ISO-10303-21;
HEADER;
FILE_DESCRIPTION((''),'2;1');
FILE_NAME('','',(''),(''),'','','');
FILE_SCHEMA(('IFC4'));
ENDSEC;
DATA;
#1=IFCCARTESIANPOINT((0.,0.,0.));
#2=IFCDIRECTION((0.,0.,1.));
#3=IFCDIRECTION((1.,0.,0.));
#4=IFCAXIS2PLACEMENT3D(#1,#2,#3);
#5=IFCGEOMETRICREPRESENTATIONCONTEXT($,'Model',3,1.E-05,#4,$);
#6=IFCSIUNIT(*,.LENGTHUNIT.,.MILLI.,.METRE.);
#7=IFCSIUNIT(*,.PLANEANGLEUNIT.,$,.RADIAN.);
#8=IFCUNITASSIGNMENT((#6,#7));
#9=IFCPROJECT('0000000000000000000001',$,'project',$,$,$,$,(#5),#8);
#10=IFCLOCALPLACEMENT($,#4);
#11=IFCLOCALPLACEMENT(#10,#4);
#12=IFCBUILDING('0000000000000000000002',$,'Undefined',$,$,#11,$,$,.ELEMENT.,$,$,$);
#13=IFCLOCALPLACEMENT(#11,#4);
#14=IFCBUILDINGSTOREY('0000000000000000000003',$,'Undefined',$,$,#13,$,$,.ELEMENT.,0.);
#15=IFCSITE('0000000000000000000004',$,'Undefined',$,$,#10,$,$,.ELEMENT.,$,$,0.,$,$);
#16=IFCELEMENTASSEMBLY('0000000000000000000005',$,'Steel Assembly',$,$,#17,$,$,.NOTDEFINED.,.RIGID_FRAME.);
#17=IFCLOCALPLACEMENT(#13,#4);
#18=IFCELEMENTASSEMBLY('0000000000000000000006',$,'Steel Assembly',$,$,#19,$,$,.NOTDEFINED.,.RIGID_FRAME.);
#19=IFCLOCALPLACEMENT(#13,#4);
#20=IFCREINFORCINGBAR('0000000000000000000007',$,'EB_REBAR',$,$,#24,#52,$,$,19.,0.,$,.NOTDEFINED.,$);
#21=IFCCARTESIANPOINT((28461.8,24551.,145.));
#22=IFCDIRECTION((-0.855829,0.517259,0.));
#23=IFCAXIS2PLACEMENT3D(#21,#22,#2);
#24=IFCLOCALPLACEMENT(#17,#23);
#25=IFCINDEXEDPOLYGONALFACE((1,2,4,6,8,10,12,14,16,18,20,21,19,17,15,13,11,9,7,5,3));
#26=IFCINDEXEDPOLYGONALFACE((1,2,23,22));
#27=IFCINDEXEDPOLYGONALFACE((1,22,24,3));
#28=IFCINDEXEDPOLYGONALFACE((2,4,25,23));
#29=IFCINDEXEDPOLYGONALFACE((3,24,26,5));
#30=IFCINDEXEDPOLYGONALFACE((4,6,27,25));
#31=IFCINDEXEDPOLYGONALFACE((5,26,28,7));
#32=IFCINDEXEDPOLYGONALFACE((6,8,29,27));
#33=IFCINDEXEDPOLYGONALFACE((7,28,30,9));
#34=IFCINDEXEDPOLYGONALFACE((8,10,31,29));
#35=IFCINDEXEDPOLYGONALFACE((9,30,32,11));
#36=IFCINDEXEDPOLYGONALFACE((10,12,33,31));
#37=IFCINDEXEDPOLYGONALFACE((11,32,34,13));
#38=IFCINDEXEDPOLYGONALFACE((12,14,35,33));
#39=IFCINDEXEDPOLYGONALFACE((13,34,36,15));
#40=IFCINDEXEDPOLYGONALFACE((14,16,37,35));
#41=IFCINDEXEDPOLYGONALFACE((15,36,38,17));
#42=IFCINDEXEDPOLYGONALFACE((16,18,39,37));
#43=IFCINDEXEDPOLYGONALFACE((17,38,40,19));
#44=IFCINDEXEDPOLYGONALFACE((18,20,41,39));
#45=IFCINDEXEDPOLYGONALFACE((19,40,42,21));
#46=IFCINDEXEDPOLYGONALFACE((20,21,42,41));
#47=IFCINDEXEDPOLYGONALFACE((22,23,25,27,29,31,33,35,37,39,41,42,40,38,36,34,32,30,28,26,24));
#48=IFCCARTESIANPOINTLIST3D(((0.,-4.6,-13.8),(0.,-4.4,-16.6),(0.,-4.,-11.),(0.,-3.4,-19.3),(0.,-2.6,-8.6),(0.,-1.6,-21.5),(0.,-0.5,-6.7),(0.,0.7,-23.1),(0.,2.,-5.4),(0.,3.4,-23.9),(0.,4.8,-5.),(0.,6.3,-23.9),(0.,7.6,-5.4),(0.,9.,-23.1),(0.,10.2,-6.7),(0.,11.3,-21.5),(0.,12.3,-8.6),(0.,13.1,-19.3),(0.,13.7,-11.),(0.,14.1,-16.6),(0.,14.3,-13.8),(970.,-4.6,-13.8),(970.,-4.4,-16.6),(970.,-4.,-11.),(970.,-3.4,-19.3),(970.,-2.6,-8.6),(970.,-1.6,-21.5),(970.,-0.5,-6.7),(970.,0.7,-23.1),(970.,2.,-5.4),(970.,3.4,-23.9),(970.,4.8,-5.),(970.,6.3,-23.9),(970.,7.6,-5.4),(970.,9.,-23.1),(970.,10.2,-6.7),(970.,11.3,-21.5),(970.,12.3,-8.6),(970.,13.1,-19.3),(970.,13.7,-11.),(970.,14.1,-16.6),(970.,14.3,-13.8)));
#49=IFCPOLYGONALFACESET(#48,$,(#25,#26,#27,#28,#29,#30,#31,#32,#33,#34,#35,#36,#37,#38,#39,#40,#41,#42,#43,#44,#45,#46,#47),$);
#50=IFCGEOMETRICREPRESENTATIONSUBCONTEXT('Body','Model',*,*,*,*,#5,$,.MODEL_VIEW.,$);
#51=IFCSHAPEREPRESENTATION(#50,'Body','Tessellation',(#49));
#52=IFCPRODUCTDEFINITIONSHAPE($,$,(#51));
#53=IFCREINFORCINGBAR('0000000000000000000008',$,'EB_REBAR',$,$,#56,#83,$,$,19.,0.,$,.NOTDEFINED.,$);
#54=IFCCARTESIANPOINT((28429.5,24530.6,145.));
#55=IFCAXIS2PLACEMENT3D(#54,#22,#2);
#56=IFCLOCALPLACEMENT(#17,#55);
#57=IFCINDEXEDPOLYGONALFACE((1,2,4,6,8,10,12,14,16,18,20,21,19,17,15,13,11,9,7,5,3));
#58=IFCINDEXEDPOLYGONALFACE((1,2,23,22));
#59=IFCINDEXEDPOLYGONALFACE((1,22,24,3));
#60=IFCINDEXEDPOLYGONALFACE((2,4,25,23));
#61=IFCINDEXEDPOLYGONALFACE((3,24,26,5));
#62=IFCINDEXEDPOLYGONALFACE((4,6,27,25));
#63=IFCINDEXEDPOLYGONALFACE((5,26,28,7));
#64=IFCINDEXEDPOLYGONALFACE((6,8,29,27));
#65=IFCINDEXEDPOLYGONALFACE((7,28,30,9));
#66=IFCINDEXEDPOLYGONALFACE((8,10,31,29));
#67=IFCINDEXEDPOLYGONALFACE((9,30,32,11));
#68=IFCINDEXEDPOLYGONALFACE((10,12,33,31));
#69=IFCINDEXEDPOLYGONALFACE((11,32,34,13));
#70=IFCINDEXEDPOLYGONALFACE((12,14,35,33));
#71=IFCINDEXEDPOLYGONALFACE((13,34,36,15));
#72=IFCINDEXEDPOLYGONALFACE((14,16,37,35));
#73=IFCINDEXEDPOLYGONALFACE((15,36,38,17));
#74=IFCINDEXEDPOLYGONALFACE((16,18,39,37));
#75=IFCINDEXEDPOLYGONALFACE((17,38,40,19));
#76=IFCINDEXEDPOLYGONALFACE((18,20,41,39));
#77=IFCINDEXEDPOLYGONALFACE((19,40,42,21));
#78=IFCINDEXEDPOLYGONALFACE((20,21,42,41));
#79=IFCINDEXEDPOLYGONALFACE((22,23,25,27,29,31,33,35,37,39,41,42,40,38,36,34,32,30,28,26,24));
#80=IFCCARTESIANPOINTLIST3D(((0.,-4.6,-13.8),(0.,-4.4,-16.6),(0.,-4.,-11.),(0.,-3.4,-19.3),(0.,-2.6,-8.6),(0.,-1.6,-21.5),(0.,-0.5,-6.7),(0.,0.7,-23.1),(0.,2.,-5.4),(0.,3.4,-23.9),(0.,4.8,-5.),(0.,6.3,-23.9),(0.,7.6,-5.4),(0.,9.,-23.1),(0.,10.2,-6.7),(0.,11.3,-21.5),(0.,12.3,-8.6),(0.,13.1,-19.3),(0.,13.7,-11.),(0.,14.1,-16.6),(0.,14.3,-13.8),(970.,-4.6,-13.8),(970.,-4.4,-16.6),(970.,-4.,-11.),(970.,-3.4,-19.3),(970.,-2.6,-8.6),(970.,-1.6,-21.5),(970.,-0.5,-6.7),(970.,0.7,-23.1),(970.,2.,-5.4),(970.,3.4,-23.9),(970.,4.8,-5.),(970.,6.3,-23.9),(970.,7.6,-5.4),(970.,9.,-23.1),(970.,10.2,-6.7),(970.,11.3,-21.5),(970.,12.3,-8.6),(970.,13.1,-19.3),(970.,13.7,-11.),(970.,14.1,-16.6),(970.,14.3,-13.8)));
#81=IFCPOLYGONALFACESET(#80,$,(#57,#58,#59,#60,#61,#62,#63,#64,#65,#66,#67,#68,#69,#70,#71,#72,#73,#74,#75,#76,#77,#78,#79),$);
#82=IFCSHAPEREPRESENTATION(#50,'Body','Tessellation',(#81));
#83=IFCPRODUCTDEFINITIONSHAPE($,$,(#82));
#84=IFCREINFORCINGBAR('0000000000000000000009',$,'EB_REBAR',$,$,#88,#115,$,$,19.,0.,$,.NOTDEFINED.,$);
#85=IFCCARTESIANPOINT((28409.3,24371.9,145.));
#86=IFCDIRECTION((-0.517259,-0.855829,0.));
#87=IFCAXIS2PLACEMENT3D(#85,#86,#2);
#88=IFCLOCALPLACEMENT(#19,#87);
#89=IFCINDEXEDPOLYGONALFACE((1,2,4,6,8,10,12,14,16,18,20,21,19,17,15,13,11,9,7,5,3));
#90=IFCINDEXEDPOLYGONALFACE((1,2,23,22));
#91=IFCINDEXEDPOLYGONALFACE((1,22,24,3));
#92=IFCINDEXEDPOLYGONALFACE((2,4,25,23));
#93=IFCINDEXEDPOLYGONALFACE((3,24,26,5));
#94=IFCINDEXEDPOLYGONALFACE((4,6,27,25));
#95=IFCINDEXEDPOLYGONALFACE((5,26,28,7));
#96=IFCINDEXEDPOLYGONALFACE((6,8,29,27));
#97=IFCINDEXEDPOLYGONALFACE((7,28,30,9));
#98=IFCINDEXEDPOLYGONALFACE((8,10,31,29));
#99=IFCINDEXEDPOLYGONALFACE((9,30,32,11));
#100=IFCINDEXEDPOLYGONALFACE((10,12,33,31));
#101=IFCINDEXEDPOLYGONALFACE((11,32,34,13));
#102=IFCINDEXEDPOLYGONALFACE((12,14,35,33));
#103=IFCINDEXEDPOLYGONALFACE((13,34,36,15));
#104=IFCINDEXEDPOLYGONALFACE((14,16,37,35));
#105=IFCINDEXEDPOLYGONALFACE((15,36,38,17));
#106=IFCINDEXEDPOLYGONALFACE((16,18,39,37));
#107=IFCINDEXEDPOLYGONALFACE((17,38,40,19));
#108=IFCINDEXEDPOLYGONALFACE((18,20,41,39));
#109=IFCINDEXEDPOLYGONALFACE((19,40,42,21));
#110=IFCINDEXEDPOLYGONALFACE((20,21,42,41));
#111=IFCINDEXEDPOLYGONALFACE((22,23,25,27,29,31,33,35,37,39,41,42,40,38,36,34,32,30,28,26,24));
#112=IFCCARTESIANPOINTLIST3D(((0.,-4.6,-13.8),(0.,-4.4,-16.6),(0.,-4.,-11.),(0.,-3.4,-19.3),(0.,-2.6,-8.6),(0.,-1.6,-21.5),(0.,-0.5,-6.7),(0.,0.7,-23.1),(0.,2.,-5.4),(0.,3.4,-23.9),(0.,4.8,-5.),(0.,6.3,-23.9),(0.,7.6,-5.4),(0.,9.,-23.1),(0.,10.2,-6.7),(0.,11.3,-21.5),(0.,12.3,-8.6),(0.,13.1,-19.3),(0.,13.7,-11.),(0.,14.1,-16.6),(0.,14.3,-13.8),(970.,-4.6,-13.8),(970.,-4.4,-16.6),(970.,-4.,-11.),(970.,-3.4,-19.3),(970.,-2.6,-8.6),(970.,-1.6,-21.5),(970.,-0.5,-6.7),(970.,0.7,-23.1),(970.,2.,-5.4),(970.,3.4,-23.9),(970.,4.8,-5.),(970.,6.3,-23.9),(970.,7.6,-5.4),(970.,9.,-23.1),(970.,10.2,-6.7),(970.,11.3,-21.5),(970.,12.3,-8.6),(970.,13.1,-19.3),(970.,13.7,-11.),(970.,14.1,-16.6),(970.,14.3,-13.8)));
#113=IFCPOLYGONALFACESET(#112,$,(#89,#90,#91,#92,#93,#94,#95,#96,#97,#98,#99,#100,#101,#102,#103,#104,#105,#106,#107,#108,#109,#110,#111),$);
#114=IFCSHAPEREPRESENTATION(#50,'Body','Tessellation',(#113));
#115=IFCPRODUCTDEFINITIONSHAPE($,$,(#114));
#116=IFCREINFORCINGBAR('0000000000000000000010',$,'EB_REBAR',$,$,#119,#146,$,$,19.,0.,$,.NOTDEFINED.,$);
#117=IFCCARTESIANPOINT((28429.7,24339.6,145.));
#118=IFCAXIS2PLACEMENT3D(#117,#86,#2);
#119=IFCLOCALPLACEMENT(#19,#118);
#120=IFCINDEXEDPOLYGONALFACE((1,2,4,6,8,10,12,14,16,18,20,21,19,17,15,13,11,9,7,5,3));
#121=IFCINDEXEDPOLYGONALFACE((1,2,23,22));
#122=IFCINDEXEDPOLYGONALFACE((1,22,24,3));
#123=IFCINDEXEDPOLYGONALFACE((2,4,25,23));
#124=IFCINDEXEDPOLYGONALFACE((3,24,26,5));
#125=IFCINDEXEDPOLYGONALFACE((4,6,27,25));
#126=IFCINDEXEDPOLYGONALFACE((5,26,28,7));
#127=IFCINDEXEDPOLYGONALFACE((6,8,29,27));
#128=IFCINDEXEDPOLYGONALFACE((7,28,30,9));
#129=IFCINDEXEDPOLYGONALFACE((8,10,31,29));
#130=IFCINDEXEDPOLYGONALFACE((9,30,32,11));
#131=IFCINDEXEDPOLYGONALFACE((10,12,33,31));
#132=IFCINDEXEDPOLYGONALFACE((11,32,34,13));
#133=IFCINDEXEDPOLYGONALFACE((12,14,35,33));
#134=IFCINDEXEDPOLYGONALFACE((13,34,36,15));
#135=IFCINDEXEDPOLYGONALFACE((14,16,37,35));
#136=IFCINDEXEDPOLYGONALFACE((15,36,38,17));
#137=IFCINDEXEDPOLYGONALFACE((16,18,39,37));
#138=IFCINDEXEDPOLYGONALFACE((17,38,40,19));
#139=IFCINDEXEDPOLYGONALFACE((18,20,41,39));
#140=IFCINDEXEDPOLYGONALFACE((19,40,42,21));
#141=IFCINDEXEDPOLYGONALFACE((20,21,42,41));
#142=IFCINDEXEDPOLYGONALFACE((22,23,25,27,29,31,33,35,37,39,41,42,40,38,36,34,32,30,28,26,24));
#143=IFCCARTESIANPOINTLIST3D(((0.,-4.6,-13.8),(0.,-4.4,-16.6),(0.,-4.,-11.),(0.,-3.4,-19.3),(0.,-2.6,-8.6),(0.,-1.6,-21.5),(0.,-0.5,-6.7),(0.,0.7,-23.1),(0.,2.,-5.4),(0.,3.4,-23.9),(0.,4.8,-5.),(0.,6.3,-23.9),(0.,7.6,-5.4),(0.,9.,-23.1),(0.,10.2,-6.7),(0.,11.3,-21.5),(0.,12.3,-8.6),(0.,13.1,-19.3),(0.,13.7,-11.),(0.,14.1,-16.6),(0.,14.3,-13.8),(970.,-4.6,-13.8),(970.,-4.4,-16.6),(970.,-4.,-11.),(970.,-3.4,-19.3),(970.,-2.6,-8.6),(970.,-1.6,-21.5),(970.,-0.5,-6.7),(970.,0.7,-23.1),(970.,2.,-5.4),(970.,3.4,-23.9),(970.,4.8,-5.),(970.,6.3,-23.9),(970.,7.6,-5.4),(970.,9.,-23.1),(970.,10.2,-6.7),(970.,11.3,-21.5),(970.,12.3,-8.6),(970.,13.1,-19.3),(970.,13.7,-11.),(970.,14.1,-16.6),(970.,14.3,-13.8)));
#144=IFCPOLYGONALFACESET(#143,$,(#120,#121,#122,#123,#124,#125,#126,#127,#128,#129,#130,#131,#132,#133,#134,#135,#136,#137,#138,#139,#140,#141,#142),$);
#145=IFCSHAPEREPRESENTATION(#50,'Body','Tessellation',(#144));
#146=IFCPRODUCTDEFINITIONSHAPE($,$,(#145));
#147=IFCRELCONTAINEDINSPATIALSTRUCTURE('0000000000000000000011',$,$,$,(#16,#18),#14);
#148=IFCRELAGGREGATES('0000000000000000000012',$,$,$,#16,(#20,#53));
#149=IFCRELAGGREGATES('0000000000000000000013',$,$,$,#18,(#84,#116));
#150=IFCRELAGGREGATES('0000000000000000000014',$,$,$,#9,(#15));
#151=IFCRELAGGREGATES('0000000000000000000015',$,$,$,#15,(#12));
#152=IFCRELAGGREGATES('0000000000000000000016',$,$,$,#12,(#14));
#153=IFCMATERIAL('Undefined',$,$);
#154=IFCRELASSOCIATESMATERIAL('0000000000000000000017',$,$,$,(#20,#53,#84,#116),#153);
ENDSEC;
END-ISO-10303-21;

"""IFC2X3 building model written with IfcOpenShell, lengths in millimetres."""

from ifc_helpers import new_model, entity, si_unit, frame, origin_with_axes, place, context, subcontext, project, spatial, source, transform, mapped, material, element, aggregate, save


model = new_model("IFC2X3")

# Units and contexts
model_context = context("Model", 3, precision=1e-05, world=origin_with_axes())
body_context = subcontext(model_context, "Body", "Model", "MODEL_VIEW")
ifc_project = project(units=[si_unit("LENGTHUNIT", "METRE", prefix="MILLI"), si_unit("PLANEANGLEUNIT", "RADIAN")], contexts=[model_context])

# Site, building, storey
site_placement = place(None, origin_with_axes())
site = spatial("IfcSite", under=ifc_project, at=site_placement, Name="Undefined", CompositionType="ELEMENT", RefElevation=0.0)
building_placement = place(site_placement, origin_with_axes())
building = spatial("IfcBuilding", under=site, at=building_placement, Name="Undefined", CompositionType="ELEMENT")
storey_placement = place(building_placement, origin_with_axes())
storey = spatial("IfcBuildingStorey", under=building, at=storey_placement, Name="Undefined", CompositionType="ELEMENT", Elevation=0.0)

# Element assemblies
assembly_1_placement = place(storey_placement, origin_with_axes())
assembly_1 = element("IfcElementAssembly", 1, at=assembly_1_placement, inside=storey, Name="Steel Assembly", AssemblyPlace="NOTDEFINED", PredefinedType="RIGID_FRAME")
assembly_2_placement = place(storey_placement, origin_with_axes())
assembly_2 = element("IfcElementAssembly", 2, at=assembly_2_placement, inside=storey, Name="Steel Assembly", AssemblyPlace="NOTDEFINED", PredefinedType="RIGID_FRAME")

# Shared definitions
ifc_material_1 = material(Name="Undefined")

# Reinforcing bars
shared_shape_1 = source(origin_with_axes(), body_context, "Body", "AdvancedSweptSolid", [
    entity("IfcSweptDiskSolid", entity("IfcTrimmedCurve", entity("IfcLine", entity("IfcCartesianPoint", [0.0, 0.0, 0.0]), entity("IfcVector", entity("IfcDirection", [1.0, 0.0, 0.0]), 1.0)), [entity("IfcParameterValue", 0.0)], [entity("IfcParameterValue", 969.999996)], True, "PARAMETER"), 9.5, None, 0.0, 970.0),
])
reinforcing_bar_1_placement = place(assembly_1_placement, frame((28461.8, 24551.0, 145.0), z_axis=(-0.855829, 0.517259, 0.0), x_axis=(0.0, 0.0, 1.0)))
reinforcing_bar_1 = element("IfcReinforcingBar", 3, at=reinforcing_bar_1_placement, material=ifc_material_1, Name="EB_REBAR", BarRole="NOTDEFINED", CrossSectionArea=0.0, NominalDiameter=19.0, context=body_context, shape_type="MappedRepresentation", body=[
    mapped(shared_shape_1, transform((0.0, 4.8, -14.5))),
])
shared_shape_2 = source(origin_with_axes(), body_context, "Body", "AdvancedSweptSolid", [
    entity("IfcSweptDiskSolid", entity("IfcTrimmedCurve", entity("IfcLine", entity("IfcCartesianPoint", [0.0, 0.0, 0.0]), entity("IfcVector", entity("IfcDirection", [1.0, 0.0, 0.0]), 1.0)), [entity("IfcParameterValue", 0.0)], [entity("IfcParameterValue", 969.999905)], True, "PARAMETER"), 9.5, None, 0.0, 970.0),
])
reinforcing_bar_2_placement = place(assembly_1_placement, frame((28429.5, 24530.6, 145.0), z_axis=(-0.855829, 0.517259, 0.0), x_axis=(0.0, 0.0, 1.0)))
reinforcing_bar_2 = element("IfcReinforcingBar", 4, at=reinforcing_bar_2_placement, material=ifc_material_1, Name="EB_REBAR", BarRole="NOTDEFINED", CrossSectionArea=0.0, NominalDiameter=19.0, context=body_context, shape_type="MappedRepresentation", body=[
    mapped(shared_shape_2, transform((0.0, 4.8, -14.5))),
])
aggregate(assembly_1, [reinforcing_bar_1, reinforcing_bar_2])
shared_shape_3 = source(origin_with_axes(), body_context, "Body", "AdvancedSweptSolid", [
    entity("IfcSweptDiskSolid", entity("IfcTrimmedCurve", entity("IfcLine", entity("IfcCartesianPoint", [0.0, 0.0, 0.0]), entity("IfcVector", entity("IfcDirection", [1.0, 0.0, 0.0]), 1.0)), [entity("IfcParameterValue", 0.0)], [entity("IfcParameterValue", 969.999996)], True, "PARAMETER"), 9.5, None, 0.0, 970.0),
])
reinforcing_bar_3_placement = place(assembly_2_placement, frame((28409.3, 24371.9, 145.0), z_axis=(-0.517259, -0.855829, 0.0), x_axis=(0.0, 0.0, 1.0)))
reinforcing_bar_3 = element("IfcReinforcingBar", 5, at=reinforcing_bar_3_placement, material=ifc_material_1, Name="EB_REBAR", BarRole="NOTDEFINED", CrossSectionArea=0.0, NominalDiameter=19.0, context=body_context, shape_type="MappedRepresentation", body=[
    mapped(shared_shape_3, transform((0.0, 4.8, -14.5))),
])
shared_shape_4 = source(origin_with_axes(), body_context, "Body", "AdvancedSweptSolid", [
    entity("IfcSweptDiskSolid", entity("IfcTrimmedCurve", entity("IfcLine", entity("IfcCartesianPoint", [0.0, 0.0, 0.0]), entity("IfcVector", entity("IfcDirection", [1.0, 0.0, 0.0]), 1.0)), [entity("IfcParameterValue", 0.0)], [entity("IfcParameterValue", 969.999905)], True, "PARAMETER"), 9.5, None, 0.0, 970.0),
])
reinforcing_bar_4_placement = place(assembly_2_placement, frame((28429.7, 24339.6, 145.0), z_axis=(-0.517259, -0.855829, 0.0), x_axis=(0.0, 0.0, 1.0)))
reinforcing_bar_4 = element("IfcReinforcingBar", 6, at=reinforcing_bar_4_placement, material=ifc_material_1, Name="EB_REBAR", BarRole="NOTDEFINED", CrossSectionArea=0.0, NominalDiameter=19.0, context=body_context, shape_type="MappedRepresentation", body=[
    mapped(shared_shape_4, transform((0.0, 4.8, -14.5))),
])
aggregate(assembly_2, [reinforcing_bar_3, reinforcing_bar_4])

save(model, "model.ifc")
